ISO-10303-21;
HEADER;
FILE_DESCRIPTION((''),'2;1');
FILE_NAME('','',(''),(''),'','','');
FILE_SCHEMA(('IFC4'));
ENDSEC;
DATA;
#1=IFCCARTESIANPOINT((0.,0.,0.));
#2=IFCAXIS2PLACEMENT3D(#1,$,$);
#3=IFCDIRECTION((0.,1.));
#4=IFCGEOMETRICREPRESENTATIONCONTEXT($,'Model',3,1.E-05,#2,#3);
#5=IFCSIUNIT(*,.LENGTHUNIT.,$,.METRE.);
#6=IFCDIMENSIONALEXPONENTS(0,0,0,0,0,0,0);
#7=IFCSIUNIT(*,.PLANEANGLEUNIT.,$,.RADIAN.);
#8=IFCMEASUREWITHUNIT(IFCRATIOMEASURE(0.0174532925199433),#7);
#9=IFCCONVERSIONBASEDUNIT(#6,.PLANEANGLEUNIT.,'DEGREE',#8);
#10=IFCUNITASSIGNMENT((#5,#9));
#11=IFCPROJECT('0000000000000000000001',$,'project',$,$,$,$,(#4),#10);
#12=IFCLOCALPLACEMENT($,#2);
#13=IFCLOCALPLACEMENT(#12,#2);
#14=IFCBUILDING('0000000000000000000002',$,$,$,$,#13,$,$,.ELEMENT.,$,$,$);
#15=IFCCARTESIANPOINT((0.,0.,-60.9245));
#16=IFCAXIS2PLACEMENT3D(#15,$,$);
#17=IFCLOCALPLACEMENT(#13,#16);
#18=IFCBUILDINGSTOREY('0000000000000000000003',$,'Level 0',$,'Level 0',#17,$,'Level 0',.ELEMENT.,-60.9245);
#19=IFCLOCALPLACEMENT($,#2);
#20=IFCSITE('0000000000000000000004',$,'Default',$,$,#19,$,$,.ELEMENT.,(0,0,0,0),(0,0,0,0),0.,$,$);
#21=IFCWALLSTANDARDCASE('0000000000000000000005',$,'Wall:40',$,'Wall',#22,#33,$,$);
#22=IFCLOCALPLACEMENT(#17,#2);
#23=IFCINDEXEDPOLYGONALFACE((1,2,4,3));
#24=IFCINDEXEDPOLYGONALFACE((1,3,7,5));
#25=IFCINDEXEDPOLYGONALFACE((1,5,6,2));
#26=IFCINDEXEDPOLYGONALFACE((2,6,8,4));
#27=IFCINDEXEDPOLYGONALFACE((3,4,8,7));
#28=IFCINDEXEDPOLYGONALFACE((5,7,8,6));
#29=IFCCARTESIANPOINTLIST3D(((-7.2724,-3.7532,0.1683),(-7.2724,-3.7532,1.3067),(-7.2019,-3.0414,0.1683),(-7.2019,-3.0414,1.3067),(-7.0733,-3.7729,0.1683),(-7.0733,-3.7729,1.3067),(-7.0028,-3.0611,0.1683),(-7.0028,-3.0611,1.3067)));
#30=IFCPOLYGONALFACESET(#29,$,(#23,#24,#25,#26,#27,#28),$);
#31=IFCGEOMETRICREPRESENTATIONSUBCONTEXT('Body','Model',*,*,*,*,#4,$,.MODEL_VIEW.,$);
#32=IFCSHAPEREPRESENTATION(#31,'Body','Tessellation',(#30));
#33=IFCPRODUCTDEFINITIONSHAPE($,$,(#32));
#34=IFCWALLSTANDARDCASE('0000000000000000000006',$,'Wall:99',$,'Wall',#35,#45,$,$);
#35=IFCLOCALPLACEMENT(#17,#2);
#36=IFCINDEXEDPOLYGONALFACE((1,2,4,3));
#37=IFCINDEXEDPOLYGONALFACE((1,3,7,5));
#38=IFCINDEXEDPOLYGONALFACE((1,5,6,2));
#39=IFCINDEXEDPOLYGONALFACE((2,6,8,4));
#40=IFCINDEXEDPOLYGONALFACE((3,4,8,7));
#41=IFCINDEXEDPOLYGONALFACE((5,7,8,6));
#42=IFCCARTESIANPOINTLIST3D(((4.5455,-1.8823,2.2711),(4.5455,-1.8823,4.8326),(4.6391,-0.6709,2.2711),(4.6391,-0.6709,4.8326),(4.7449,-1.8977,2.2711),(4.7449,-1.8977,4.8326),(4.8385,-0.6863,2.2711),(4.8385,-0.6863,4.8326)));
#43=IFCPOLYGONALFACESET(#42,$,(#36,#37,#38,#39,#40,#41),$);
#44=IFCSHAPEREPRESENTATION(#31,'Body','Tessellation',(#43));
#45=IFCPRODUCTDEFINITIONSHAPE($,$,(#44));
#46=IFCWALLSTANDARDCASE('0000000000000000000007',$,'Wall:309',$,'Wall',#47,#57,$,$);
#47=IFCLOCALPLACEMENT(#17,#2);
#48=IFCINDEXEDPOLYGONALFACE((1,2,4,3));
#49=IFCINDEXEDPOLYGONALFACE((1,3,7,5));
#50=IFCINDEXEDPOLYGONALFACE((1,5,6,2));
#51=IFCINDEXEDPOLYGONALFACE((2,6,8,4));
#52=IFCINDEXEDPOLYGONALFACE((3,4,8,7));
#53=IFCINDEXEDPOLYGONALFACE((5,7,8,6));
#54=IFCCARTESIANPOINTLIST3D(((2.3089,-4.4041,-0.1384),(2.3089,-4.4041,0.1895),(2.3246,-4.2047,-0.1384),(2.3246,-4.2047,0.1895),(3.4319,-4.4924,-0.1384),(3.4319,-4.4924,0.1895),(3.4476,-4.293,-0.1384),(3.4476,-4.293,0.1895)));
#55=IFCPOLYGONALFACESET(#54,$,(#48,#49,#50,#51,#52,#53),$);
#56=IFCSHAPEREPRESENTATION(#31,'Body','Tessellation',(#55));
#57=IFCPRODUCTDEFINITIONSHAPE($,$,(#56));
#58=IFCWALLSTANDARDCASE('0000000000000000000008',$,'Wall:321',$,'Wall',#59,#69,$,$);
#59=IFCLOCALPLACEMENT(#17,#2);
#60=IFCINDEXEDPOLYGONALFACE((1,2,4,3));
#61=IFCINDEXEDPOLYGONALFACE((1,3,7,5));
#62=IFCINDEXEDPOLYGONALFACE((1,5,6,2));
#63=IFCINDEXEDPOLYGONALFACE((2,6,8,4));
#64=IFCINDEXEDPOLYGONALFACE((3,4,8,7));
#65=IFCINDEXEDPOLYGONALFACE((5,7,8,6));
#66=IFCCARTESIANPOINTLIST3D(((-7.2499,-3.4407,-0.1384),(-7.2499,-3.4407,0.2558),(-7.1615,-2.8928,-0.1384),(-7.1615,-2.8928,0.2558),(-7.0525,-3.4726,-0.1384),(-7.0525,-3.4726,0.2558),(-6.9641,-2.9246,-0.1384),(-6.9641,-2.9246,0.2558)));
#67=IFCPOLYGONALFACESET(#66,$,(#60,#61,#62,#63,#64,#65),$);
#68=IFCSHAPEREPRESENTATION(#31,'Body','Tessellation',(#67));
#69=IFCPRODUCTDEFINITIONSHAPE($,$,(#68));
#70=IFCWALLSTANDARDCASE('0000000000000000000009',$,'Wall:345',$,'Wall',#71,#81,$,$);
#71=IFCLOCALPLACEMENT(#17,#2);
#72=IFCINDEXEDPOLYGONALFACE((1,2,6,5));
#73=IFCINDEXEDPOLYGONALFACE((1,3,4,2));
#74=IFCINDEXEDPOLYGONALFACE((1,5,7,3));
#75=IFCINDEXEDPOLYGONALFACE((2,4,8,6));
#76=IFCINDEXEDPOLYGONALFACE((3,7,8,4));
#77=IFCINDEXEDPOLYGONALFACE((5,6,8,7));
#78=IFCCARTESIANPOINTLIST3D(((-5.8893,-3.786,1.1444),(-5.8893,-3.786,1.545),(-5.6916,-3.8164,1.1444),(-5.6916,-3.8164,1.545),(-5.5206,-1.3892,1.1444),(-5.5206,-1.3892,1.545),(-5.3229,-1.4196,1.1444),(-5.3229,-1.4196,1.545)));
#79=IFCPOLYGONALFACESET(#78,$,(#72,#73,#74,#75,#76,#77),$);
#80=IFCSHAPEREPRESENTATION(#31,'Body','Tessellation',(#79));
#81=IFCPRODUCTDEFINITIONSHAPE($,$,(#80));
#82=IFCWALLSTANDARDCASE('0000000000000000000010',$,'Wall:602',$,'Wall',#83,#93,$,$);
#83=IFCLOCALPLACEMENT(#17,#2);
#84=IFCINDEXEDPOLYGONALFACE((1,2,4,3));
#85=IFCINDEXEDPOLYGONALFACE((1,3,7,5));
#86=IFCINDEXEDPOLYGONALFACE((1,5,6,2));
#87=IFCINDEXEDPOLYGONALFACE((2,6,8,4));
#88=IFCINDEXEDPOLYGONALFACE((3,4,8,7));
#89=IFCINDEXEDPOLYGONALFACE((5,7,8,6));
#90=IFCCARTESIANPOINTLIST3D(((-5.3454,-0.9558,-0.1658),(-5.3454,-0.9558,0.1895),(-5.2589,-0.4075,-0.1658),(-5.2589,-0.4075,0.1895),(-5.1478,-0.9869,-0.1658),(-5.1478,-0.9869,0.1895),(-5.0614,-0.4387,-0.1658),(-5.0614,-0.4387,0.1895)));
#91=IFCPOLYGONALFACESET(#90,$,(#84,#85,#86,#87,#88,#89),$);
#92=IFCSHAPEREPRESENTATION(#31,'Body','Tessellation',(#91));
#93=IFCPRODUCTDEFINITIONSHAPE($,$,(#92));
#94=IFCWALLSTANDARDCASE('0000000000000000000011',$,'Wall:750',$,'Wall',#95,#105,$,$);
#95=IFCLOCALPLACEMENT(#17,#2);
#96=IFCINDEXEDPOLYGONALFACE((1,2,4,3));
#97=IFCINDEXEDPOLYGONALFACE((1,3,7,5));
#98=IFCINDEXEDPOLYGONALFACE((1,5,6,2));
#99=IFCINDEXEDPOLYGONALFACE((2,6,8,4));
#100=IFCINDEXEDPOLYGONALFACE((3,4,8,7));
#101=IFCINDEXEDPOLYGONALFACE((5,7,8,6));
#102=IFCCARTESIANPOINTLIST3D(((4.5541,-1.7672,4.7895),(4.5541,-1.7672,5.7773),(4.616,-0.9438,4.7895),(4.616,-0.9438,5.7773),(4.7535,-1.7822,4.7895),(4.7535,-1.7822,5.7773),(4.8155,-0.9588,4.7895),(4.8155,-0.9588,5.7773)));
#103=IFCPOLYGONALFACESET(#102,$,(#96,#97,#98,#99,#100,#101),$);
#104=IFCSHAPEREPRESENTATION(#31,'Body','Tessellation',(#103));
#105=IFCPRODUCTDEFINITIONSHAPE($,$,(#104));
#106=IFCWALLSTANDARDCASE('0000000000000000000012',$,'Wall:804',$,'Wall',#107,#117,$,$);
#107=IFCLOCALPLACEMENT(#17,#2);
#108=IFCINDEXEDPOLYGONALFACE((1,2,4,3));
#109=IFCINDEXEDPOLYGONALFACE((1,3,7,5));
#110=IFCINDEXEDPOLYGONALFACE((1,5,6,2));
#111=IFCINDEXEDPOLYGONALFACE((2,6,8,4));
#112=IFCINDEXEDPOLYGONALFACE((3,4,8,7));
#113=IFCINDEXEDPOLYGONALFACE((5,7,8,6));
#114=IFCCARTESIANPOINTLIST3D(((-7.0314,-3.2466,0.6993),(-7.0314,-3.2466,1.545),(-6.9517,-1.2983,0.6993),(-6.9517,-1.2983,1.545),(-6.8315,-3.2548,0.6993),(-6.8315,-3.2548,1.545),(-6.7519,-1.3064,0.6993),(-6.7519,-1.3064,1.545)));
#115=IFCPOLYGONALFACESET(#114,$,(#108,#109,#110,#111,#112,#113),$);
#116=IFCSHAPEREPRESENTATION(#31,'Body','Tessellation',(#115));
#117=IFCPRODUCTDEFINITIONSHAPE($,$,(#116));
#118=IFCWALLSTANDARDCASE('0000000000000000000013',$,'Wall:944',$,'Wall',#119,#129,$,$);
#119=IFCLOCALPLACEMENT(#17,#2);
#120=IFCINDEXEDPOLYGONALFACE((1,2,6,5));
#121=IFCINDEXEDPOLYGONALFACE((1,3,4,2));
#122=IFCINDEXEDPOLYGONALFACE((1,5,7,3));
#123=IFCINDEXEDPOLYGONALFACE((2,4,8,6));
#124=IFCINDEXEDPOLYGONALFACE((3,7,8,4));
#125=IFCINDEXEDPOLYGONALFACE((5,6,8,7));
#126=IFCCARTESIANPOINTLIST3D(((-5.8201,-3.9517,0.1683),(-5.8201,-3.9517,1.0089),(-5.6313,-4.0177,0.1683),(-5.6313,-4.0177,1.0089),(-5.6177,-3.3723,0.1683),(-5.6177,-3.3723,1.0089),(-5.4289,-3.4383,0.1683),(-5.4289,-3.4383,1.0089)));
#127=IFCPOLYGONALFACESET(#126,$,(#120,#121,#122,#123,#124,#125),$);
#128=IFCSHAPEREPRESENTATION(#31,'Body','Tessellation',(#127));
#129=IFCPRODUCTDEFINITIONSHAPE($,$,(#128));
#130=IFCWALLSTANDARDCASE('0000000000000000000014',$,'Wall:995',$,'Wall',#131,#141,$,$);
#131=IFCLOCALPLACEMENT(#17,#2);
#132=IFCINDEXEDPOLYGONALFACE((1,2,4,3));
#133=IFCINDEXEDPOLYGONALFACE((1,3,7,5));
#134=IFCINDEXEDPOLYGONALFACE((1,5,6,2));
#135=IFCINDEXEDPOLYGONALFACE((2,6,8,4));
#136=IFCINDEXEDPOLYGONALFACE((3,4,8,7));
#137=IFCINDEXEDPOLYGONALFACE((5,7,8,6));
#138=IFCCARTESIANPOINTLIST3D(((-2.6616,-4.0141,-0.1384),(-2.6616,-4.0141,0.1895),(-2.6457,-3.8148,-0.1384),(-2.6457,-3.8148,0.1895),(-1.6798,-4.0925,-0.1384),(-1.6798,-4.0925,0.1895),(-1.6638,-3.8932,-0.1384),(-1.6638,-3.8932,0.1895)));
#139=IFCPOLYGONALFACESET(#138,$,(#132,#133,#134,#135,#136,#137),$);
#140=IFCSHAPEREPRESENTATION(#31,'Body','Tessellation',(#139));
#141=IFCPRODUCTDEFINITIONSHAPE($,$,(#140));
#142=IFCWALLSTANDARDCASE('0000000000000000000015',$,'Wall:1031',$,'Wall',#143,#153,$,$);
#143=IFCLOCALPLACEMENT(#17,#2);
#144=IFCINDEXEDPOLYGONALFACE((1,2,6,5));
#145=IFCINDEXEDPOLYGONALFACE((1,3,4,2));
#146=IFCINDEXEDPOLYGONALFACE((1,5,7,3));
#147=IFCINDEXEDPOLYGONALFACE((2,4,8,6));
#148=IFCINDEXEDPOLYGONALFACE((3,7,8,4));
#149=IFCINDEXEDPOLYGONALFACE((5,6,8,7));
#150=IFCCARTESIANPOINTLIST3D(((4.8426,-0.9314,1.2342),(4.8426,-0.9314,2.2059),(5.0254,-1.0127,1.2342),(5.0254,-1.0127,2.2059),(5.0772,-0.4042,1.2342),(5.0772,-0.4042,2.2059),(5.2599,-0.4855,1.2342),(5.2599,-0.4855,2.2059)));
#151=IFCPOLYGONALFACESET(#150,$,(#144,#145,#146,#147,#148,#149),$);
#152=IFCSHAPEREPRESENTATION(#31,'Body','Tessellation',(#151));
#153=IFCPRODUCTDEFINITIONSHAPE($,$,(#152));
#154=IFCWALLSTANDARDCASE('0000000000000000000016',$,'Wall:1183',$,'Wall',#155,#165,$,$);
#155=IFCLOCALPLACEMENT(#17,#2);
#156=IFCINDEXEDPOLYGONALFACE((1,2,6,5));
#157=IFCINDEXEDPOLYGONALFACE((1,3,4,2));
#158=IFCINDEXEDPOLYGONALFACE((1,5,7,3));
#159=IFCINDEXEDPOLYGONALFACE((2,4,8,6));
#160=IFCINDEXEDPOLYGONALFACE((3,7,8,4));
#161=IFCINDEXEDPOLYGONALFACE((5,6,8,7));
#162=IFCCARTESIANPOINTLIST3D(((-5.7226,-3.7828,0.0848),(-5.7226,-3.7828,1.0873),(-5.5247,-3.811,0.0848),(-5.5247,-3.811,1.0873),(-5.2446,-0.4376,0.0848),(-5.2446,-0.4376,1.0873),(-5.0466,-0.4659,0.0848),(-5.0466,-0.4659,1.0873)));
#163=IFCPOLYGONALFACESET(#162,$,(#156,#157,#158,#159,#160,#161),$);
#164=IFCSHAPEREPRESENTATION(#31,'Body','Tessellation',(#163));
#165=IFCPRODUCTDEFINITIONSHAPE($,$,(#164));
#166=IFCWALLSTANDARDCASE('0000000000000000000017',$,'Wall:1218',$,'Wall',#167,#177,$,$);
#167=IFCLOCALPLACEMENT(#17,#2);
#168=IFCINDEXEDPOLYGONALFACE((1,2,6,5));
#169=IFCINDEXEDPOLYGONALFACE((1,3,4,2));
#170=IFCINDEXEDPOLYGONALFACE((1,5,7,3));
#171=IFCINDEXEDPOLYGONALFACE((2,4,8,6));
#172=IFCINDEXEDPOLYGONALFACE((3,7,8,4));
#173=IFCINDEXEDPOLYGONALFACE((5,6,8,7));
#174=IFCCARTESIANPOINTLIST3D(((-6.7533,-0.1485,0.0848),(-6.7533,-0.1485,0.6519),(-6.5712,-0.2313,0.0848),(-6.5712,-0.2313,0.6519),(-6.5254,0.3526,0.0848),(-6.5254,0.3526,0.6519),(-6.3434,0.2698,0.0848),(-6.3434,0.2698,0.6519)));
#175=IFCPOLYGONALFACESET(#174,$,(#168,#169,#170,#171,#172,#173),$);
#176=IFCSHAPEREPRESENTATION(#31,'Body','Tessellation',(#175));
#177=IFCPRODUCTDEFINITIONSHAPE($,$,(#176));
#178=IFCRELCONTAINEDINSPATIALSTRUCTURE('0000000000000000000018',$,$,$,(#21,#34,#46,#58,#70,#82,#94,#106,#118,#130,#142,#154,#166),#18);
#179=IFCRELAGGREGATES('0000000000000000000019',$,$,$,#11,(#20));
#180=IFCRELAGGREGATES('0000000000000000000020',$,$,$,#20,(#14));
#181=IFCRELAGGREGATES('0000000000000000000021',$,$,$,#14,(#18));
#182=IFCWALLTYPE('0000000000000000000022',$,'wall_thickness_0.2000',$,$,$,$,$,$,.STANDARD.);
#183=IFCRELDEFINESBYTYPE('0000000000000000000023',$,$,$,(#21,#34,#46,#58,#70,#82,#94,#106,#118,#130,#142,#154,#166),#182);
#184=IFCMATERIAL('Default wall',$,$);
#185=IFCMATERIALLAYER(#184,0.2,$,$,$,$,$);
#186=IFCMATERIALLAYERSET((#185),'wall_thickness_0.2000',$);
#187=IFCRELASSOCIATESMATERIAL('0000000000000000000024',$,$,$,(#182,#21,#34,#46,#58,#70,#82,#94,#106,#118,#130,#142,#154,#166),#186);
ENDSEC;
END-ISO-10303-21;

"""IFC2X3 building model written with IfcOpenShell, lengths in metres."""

from ifc_helpers import new_model, entity, si_unit, converted_unit, direction, frame, origin, place, context, subcontext, project, spatial, polyline, outline, extrude, material, layer, layer_set, layer_usage, type_object, element, save


model = new_model("IFC2X3")

# Units and contexts
model_context = context("Model", 3, precision=1e-05, world=origin(), true_north=direction((0.0, 1.0)))
body_context = subcontext(model_context, "Body", "Model", "MODEL_VIEW")
ifc_project = project(units=[si_unit("LENGTHUNIT", "METRE"), converted_unit("PLANEANGLEUNIT", "DEGREE", entity("IfcRatioMeasure", 0.0174532925199433), si_unit("PLANEANGLEUNIT", "RADIAN"), dimensions=[0, 0, 0, 0, 0, 0, 0])], contexts=[model_context])

# Site, building, storey
site_placement = place(None, origin())
site = spatial("IfcSite", under=ifc_project, at=site_placement, Name="Default", CompositionType="ELEMENT", RefLatitude=(0, 0, 0, 0), RefLongitude=(0, 0, 0, 0), RefElevation=0.0)
placement_1 = place(None, origin())
building_placement = place(placement_1, origin())
building = spatial("IfcBuilding", under=site, at=building_placement, CompositionType="ELEMENT")
storey_placement = place(building_placement, frame((0.0, 0.0, -60.9245)))
storey = spatial("IfcBuildingStorey", under=building, at=storey_placement, Name="Level 0", ObjectType="Level 0", LongName="Level 0", CompositionType="ELEMENT", Elevation=-60.9245)

# Walls
ifc_material = material(Name="Default wall")
ifc_layer = layer(ifc_material, 0.2)
ifc_layer_set = layer_set([ifc_layer], Name="wall_thickness_0.2000")
ifc_layer_usage = layer_usage(ifc_layer_set, "AXIS2", "POSITIVE", -0.1)
wall_type = type_object("IfcWallType", Name="wall_thickness_0.2000", PredefinedType="STANDARD", material=ifc_layer_set)
placement_2 = place(building_placement, frame((0.0, 0.0, -60.7562)))
wall_1_placement = place(placement_2, frame((-7.1024, -3.0512, 0.0), z_axis=(0.0, 0.0, 1.0), x_axis=(-0.098554, -0.995132, 0.0)))
element("IfcWallStandardCase", 1, at=wall_1_placement, inside=storey, type_object=wall_type, material=ifc_layer_usage, Name="Wall:40", ObjectType="Wall", context=body_context, shape_type="SweptSolid", body=[
    extrude(outline(polyline([(0.7153, -0.1), (0.7153, 0.1), (0.0, 0.1), (0.0, -0.1), (0.7153, -0.1)])), origin(), (0.0, 0.0, 1.0), 1.1384),
])
placement_3 = place(building_placement, frame((0.0, 0.0, -58.6534)))
wall_2_placement = place(placement_3, frame((4.7388, -0.6786, 0.0), z_axis=(0.0, 0.0, 1.0), x_axis=(-0.076986, -0.997032, 0.0)))
element("IfcWallStandardCase", 2, at=wall_2_placement, inside=storey, type_object=wall_type, material=ifc_layer_usage, Name="Wall:99", ObjectType="Wall", context=body_context, shape_type="SweptSolid", body=[
    extrude(outline(polyline([(1.215, -0.1), (1.215, 0.1), (0.0, 0.1), (0.0, -0.1), (1.215, -0.1)])), origin(), (0.0, 0.0, 1.0), 2.5615),
])
placement_4 = place(building_placement, frame((0.0, 0.0, -61.0629)))
wall_3_placement = place(placement_4, frame((2.3168, -4.3044, 0.0), z_axis=(0.0, 0.0, 1.0), x_axis=(0.996921, -0.078408, 0.0)))
element("IfcWallStandardCase", 3, at=wall_3_placement, inside=storey, type_object=wall_type, material=ifc_layer_usage, Name="Wall:309", ObjectType="Wall", context=body_context, shape_type="SweptSolid", body=[
    extrude(outline(polyline([(1.1264, -0.1), (1.1264, 0.1), (0.0, 0.1), (0.0, -0.1), (1.1264, -0.1)])), origin(), (0.0, 0.0, 1.0), 0.3279),
])
placement_5 = place(building_placement, frame((0.0, 0.0, -61.0629)))
wall_4_placement = place(placement_5, frame((-7.0628, -2.9087, 0.0), z_axis=(0.0, 0.0, 1.0), x_axis=(-0.159319, -0.987227, 0.0)))
element("IfcWallStandardCase", 4, at=wall_4_placement, inside=storey, type_object=wall_type, material=ifc_layer_usage, Name="Wall:321", ObjectType="Wall", context=body_context, shape_type="SweptSolid", body=[
    extrude(outline(polyline([(0.555, -0.1), (0.555, 0.1), (0.0, 0.1), (0.0, -0.1), (0.555, -0.1)])), origin(), (0.0, 0.0, 1.0), 0.3942),
])
placement_6 = place(building_placement, frame((0.0, 0.0, -59.7801)))
wall_5_placement = place(placement_6, frame((-5.7904, -3.8012, 0.0), z_axis=(0.0, 0.0, 1.0), x_axis=(0.152014, 0.988378, 0.0)))
element("IfcWallStandardCase", 5, at=wall_5_placement, inside=storey, type_object=wall_type, material=ifc_layer_usage, Name="Wall:345", ObjectType="Wall", context=body_context, shape_type="SweptSolid", body=[
    extrude(outline(polyline([(2.425, -0.1), (2.425, 0.1), (0.0, 0.1), (0.0, -0.1), (2.425, -0.1)])), origin(), (0.0, 0.0, 1.0), 0.4006),
])
placement_7 = place(building_placement, frame((0.0, 0.0, -61.0903)))
wall_6_placement = place(placement_7, frame((-5.1602, -0.4231, 0.0), z_axis=(0.0, 0.0, 1.0), x_axis=(-0.155767, -0.987794, 0.0)))
element("IfcWallStandardCase", 6, at=wall_6_placement, inside=storey, type_object=wall_type, material=ifc_layer_usage, Name="Wall:602", ObjectType="Wall", context=body_context, shape_type="SweptSolid", body=[
    extrude(outline(polyline([(0.555, -0.1), (0.555, 0.1), (0.0, 0.1), (0.0, -0.1), (0.555, -0.1)])), origin(), (0.0, 0.0, 1.0), 0.3553),
])
placement_8 = place(building_placement, frame((0.0, 0.0, -56.135)))
wall_7_placement = place(placement_8, frame((4.6538, -1.7747, 0.0), z_axis=(0.0, 0.0, 1.0), x_axis=(0.075028, 0.997181, 0.0)))
element("IfcWallStandardCase", 7, at=wall_7_placement, inside=storey, type_object=wall_type, material=ifc_layer_usage, Name="Wall:750", ObjectType="Wall", context=body_context, shape_type="SweptSolid", body=[
    extrude(outline(polyline([(0.8257, -0.1), (0.8257, 0.1), (0.0, 0.1), (0.0, -0.1), (0.8257, -0.1)])), origin(), (0.0, 0.0, 1.0), 0.9878),
])
placement_9 = place(building_placement, frame((0.0, 0.0, -60.2252)))
wall_8_placement = place(placement_9, frame((-6.9314, -3.2507, 0.0), z_axis=(0.0, 0.0, 1.0), x_axis=(0.040835, 0.999166, 0.0)))
element("IfcWallStandardCase", 8, at=wall_8_placement, inside=storey, type_object=wall_type, material=ifc_layer_usage, Name="Wall:804", ObjectType="Wall", context=body_context, shape_type="SweptSolid", body=[
    extrude(outline(polyline([(1.95, -0.1), (1.95, 0.1), (0.0, 0.1), (0.0, -0.1), (1.95, -0.1)])), origin(), (0.0, 0.0, 1.0), 0.8457),
])
placement_10 = place(building_placement, frame((0.0, 0.0, -60.7562)))
wall_9_placement = place(placement_10, frame((-5.5233, -3.4053, 0.0), z_axis=(0.0, 0.0, 1.0), x_axis=(-0.329741, -0.944071, 0.0)))
element("IfcWallStandardCase", 9, at=wall_9_placement, inside=storey, type_object=wall_type, material=ifc_layer_usage, Name="Wall:944", ObjectType="Wall", context=body_context, shape_type="SweptSolid", body=[
    extrude(outline(polyline([(0.6137, -0.1), (0.6137, 0.1), (0.0, 0.1), (0.0, -0.1), (0.6137, -0.1)])), origin(), (0.0, 0.0, 1.0), 0.8406),
])
placement_11 = place(building_placement, frame((0.0, 0.0, -61.0629)))
wall_10_placement = place(placement_11, frame((-2.6537, -3.9145, 0.0), z_axis=(0.0, 0.0, 1.0), x_axis=(0.996828, -0.079589, 0.0)))
element("IfcWallStandardCase", 10, at=wall_10_placement, inside=storey, type_object=wall_type, material=ifc_layer_usage, Name="Wall:995", ObjectType="Wall", context=body_context, shape_type="SweptSolid", body=[
    extrude(outline(polyline([(0.985, -0.1), (0.985, 0.1), (0.0, 0.1), (0.0, -0.1), (0.985, -0.1)])), origin(), (0.0, 0.0, 1.0), 0.3279),
])
placement_12 = place(building_placement, frame((0.0, 0.0, -59.6903)))
wall_11_placement = place(placement_12, frame((4.934, -0.9721, 0.0), z_axis=(0.0, 0.0, 1.0), x_axis=(0.406462, 0.913668, 0.0)))
element("IfcWallStandardCase", 11, at=wall_11_placement, inside=storey, type_object=wall_type, material=ifc_layer_usage, Name="Wall:1031", ObjectType="Wall", context=body_context, shape_type="SweptSolid", body=[
    extrude(outline(polyline([(0.5771, -0.1), (0.5771, 0.1), (0.0, 0.1), (0.0, -0.1), (0.5771, -0.1)])), origin(), (0.0, 0.0, 1.0), 0.9717),
])
placement_13 = place(building_placement, frame((0.0, 0.0, -60.8397)))
wall_12_placement = place(placement_13, frame((-5.6236, -3.7969, 0.0), z_axis=(0.0, 0.0, 1.0), x_axis=(0.141463, 0.989944, 0.0)))
element("IfcWallStandardCase", 12, at=wall_12_placement, inside=storey, type_object=wall_type, material=ifc_layer_usage, Name="Wall:1183", ObjectType="Wall", context=body_context, shape_type="SweptSolid", body=[
    extrude(outline(polyline([(3.3792, -0.1), (3.3792, 0.1), (0.0, 0.1), (0.0, -0.1), (3.3792, -0.1)])), origin(), (0.0, 0.0, 1.0), 1.0026),
])
placement_14 = place(building_placement, frame((0.0, 0.0, -60.8397)))
wall_13_placement = place(placement_14, frame((-6.6623, -0.1899, 0.0), z_axis=(0.0, 0.0, 1.0), x_axis=(0.413902, 0.910321, 0.0)))
element("IfcWallStandardCase", 13, at=wall_13_placement, inside=storey, type_object=wall_type, material=ifc_layer_usage, Name="Wall:1218", ObjectType="Wall", context=body_context, shape_type="SweptSolid", body=[
    extrude(outline(polyline([(0.5505, -0.1), (0.5505, 0.1), (0.0, 0.1), (0.0, -0.1), (0.5505, -0.1)])), origin(), (0.0, 0.0, 1.0), 0.5671),
])

save(model, "model.ifc")
